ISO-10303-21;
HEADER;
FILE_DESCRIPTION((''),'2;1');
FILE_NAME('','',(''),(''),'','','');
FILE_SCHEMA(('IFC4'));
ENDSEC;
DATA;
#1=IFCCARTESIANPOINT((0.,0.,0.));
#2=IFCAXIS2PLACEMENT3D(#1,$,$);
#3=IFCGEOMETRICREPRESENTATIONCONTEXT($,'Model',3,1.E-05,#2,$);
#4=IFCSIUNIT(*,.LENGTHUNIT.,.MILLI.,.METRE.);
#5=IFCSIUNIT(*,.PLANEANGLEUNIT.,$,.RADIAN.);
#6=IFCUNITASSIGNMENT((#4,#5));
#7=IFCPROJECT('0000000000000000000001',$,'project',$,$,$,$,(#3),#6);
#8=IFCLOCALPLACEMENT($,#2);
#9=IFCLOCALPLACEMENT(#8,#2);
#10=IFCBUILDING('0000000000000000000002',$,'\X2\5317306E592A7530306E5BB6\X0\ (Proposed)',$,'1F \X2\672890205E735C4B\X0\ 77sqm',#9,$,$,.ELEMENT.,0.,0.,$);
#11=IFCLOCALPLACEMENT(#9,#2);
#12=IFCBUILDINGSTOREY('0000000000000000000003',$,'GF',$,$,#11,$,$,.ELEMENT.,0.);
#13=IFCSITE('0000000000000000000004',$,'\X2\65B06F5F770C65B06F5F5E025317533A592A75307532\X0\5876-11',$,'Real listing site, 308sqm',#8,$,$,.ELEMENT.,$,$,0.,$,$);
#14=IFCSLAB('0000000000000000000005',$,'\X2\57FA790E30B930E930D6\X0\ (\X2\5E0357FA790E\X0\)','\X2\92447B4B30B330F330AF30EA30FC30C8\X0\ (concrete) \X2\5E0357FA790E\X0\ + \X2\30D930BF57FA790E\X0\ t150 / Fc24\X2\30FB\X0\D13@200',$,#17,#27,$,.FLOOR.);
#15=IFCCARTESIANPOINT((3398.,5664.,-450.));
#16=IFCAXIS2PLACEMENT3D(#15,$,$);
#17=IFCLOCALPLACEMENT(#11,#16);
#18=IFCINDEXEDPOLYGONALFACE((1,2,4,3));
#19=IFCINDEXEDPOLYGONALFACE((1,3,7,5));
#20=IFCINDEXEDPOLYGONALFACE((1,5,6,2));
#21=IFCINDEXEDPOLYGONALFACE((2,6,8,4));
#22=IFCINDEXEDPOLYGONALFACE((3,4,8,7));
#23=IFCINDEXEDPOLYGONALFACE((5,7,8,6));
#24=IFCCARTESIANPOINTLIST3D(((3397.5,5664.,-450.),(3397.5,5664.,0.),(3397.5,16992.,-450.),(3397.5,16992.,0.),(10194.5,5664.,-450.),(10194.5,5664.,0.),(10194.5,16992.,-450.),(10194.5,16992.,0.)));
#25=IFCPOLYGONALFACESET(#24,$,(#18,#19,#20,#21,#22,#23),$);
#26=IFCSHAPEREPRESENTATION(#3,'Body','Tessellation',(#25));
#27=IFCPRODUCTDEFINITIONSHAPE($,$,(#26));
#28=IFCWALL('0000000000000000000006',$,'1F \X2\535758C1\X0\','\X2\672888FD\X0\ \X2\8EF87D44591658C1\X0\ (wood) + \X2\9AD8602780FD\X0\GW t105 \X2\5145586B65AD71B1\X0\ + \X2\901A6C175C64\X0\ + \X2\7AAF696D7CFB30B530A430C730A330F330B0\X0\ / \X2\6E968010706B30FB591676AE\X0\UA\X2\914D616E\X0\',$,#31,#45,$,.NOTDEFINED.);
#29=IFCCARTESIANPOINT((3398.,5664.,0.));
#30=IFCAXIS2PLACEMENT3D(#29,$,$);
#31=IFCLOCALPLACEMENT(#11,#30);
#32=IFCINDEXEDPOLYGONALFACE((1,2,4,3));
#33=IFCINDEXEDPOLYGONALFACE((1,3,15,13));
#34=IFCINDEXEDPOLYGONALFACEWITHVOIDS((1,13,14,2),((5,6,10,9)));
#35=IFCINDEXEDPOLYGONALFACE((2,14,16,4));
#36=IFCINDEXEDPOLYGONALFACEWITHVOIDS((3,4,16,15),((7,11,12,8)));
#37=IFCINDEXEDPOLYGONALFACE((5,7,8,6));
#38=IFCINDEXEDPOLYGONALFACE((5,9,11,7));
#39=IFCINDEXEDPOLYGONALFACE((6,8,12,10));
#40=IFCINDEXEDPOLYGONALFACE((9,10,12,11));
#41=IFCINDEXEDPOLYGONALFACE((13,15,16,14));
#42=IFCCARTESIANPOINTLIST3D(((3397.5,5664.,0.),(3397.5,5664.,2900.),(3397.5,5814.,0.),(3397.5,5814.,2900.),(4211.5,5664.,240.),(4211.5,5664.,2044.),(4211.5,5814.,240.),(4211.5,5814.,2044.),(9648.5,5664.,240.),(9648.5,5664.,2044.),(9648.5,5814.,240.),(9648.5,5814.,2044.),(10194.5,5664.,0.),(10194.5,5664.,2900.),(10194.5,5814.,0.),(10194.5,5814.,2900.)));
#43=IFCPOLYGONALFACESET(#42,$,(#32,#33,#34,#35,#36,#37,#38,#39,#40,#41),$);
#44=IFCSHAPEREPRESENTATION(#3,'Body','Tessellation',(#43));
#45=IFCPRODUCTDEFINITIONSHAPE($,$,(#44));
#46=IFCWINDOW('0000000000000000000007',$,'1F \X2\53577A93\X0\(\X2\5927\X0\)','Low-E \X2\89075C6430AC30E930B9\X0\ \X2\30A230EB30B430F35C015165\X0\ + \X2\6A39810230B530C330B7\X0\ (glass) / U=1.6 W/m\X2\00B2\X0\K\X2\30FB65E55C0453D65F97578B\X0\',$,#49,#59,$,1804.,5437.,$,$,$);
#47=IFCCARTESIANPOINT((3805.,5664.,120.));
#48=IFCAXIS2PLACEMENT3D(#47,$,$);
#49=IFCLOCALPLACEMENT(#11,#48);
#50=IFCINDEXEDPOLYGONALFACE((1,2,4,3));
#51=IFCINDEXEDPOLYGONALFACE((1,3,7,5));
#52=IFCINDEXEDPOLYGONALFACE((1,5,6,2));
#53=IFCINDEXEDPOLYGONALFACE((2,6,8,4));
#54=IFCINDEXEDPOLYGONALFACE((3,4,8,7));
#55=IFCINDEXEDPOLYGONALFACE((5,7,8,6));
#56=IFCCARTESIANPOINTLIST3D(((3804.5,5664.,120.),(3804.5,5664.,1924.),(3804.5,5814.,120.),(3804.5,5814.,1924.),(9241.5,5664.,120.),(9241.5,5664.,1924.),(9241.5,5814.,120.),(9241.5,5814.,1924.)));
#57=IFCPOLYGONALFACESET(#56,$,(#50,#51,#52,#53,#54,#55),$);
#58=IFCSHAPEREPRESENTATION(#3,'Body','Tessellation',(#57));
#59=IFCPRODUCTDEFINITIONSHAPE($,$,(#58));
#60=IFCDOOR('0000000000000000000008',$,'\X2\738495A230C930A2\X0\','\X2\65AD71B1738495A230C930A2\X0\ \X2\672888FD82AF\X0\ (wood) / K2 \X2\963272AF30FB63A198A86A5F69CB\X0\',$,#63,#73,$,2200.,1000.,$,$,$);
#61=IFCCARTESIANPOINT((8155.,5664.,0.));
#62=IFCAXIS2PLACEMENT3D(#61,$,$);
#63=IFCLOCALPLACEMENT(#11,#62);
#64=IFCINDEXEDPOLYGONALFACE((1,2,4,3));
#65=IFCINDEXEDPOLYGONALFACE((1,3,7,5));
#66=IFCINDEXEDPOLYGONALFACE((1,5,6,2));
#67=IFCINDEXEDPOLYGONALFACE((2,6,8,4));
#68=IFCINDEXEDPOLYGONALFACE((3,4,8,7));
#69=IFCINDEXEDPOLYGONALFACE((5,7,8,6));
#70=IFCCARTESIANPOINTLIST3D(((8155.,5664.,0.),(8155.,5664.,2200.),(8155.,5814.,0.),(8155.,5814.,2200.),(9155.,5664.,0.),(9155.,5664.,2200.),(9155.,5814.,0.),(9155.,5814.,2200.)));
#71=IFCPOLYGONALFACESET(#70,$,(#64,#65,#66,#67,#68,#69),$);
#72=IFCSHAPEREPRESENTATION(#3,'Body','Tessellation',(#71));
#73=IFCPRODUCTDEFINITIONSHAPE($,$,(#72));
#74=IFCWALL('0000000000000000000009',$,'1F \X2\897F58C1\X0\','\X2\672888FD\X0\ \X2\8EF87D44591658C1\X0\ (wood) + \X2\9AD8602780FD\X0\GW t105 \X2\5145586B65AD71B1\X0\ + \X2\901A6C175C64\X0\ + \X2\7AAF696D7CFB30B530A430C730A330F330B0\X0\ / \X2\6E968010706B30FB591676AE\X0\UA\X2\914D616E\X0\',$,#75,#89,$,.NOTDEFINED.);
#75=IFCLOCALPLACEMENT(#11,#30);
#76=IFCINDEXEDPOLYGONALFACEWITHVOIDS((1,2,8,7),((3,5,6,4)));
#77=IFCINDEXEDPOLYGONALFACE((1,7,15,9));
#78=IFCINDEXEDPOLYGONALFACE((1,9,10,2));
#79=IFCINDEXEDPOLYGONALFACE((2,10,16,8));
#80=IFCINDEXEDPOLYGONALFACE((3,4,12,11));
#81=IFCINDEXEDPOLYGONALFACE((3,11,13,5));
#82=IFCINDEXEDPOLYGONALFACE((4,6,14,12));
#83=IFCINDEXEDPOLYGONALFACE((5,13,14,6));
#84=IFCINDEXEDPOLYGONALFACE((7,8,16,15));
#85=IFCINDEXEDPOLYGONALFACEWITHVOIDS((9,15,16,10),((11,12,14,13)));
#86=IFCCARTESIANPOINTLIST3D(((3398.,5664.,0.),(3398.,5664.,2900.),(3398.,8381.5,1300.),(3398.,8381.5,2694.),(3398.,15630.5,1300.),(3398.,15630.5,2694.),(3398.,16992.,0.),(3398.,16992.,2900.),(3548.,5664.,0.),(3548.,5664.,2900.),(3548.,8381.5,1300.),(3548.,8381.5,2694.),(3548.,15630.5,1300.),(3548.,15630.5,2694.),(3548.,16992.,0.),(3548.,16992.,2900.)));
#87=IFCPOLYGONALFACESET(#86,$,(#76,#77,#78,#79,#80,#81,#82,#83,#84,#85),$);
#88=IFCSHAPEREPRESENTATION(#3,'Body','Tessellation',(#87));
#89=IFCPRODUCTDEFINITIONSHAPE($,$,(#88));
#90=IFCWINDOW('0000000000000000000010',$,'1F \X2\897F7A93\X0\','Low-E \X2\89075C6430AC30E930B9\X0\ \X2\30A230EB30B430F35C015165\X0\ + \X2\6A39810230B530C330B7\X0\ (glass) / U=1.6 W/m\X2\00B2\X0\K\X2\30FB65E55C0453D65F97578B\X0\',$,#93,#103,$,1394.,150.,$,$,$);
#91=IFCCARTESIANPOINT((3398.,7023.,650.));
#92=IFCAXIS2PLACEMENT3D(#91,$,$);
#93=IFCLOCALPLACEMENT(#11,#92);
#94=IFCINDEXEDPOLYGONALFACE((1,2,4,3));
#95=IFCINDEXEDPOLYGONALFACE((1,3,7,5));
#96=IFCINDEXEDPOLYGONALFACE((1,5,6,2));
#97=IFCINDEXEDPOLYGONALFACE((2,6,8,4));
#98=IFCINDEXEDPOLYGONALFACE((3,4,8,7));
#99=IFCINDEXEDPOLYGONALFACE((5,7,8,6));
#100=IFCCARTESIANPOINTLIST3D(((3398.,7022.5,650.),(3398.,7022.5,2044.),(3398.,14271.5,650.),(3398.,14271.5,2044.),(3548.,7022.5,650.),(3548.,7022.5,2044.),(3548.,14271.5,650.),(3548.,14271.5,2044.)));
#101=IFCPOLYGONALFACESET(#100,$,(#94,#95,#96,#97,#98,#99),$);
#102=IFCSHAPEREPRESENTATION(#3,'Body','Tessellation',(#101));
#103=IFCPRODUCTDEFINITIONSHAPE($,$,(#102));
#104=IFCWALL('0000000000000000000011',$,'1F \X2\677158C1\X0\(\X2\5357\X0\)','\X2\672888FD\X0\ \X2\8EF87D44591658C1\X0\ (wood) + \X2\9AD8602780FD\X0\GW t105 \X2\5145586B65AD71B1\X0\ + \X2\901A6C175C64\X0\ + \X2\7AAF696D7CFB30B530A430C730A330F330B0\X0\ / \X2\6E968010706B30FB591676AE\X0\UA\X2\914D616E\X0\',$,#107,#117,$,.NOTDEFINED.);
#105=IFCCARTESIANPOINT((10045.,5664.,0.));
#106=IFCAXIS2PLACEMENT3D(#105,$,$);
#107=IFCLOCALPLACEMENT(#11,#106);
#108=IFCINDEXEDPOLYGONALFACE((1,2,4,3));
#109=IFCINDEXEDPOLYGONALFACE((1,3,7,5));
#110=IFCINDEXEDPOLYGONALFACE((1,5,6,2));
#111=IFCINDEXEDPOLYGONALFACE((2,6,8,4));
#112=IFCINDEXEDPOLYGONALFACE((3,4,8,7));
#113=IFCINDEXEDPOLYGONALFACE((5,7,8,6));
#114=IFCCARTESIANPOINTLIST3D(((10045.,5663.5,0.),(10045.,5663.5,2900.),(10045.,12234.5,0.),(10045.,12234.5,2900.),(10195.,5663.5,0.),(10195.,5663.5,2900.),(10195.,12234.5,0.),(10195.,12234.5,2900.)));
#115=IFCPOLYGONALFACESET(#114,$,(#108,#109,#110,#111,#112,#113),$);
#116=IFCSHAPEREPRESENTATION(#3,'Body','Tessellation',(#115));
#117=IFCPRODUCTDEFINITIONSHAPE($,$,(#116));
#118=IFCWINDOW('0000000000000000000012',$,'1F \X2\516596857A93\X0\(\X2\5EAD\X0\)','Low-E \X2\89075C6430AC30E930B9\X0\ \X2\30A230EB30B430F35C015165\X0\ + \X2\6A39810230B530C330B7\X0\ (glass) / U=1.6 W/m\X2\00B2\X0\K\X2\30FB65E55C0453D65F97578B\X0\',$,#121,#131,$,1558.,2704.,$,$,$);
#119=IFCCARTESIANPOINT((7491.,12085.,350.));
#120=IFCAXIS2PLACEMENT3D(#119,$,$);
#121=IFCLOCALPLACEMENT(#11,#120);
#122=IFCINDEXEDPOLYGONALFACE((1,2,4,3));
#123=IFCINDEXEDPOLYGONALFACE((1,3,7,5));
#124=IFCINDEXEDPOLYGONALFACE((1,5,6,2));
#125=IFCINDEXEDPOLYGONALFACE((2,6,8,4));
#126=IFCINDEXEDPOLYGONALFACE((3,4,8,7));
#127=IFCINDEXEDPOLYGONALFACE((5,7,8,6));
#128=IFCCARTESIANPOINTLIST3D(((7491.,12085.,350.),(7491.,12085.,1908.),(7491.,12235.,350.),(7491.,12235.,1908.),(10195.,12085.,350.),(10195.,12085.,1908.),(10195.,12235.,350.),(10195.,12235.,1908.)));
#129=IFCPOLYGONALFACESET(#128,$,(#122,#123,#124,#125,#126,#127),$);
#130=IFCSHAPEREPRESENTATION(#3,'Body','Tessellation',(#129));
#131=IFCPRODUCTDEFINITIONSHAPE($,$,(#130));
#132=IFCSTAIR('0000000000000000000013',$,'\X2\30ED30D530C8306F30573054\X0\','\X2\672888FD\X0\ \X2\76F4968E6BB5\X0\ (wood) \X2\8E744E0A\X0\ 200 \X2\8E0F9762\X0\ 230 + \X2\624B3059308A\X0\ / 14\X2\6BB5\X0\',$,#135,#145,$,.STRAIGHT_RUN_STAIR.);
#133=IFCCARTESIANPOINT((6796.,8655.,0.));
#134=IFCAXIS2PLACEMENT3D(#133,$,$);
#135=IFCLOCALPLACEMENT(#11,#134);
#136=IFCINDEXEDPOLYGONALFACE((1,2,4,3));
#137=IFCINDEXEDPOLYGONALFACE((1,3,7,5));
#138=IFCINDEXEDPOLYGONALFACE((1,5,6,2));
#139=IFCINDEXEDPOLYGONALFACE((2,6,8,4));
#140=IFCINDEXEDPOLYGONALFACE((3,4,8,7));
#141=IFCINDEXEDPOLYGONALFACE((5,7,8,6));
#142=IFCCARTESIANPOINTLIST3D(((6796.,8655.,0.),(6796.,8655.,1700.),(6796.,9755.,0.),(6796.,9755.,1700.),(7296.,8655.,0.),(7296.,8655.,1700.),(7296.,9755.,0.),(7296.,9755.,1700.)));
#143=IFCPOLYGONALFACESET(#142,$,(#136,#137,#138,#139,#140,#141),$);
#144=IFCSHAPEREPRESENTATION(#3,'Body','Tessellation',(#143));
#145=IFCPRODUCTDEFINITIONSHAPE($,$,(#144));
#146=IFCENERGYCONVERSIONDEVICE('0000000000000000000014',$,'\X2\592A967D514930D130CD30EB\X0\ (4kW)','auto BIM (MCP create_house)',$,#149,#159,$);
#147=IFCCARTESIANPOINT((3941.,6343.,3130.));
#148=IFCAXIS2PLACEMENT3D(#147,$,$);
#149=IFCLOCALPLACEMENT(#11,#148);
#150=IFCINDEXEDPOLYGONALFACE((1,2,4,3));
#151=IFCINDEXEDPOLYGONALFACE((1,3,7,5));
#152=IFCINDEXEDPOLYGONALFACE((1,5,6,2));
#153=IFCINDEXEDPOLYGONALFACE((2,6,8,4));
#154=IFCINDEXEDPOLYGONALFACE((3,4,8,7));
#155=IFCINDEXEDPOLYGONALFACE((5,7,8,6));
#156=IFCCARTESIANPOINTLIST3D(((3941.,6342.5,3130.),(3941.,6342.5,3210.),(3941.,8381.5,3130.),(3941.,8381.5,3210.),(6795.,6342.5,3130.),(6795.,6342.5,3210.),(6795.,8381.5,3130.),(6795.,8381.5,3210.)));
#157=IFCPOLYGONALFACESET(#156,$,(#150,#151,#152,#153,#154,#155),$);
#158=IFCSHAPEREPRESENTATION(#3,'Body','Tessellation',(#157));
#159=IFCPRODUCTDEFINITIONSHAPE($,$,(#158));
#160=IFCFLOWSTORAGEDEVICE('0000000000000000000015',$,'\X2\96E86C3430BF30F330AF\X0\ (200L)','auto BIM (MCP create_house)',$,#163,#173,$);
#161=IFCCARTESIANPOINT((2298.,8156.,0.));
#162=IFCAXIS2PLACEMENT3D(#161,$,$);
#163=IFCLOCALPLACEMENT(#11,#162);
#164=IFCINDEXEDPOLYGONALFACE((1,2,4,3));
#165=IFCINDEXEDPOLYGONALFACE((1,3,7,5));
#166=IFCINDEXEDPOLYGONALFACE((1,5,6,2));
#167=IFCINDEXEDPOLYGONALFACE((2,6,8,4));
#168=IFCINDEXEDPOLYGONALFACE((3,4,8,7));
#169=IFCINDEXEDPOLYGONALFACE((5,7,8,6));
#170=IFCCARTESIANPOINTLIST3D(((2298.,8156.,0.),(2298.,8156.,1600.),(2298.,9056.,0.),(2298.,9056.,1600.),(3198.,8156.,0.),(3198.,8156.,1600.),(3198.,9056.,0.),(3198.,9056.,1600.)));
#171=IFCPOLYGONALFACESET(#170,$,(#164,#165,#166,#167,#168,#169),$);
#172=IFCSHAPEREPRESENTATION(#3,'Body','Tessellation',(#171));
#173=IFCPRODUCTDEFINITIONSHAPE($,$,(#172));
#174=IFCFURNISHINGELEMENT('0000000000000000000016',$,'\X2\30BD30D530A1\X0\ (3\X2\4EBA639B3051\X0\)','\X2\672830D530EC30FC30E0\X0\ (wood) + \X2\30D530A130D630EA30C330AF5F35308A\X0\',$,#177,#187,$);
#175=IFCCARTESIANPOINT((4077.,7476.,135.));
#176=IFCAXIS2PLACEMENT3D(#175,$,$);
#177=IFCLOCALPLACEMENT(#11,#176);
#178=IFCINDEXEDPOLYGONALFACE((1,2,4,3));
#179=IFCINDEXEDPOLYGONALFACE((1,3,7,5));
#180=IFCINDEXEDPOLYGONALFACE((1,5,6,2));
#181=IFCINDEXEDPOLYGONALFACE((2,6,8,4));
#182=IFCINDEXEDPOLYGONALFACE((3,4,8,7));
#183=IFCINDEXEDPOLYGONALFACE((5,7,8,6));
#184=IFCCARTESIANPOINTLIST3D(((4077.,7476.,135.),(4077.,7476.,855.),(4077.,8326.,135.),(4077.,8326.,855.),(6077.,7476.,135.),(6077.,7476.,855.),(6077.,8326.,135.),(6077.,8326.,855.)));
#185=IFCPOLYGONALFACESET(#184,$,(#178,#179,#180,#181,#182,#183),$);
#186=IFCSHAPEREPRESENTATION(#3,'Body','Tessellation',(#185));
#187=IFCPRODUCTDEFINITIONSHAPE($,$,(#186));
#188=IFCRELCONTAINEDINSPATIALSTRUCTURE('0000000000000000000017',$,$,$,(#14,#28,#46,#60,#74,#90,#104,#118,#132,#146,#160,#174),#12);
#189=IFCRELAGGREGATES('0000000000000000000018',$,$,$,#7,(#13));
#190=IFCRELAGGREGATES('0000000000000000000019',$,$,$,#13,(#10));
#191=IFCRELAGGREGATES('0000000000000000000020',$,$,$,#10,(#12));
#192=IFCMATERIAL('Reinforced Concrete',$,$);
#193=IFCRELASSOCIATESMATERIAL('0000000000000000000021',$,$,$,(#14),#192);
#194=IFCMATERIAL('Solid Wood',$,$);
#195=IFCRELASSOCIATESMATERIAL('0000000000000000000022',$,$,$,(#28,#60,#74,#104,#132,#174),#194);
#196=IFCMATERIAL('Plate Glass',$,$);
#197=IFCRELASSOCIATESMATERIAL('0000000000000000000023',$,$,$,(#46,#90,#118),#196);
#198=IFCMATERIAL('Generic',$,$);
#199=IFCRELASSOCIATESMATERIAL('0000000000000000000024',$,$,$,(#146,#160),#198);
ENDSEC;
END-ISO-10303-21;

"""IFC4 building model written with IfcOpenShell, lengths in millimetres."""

from ifc_helpers import new_model, si_unit, frame, frame_2d, origin, place, context, project, spatial, rectangle, extrude, material, element, fill, save


model = new_model("IFC4")

# Units and contexts
model_context = context("Model", 3, precision=1e-05, world=origin())
ifc_project = project(units=[si_unit("LENGTHUNIT", "METRE", prefix="MILLI"), si_unit("PLANEANGLEUNIT", "RADIAN")], contexts=[model_context])

# Site, building, storey
site_placement = place(None, origin())
site = spatial("IfcSite", under=ifc_project, at=site_placement, Name="新潟県新潟市北区太田甲5876-11", ObjectType="Real listing site, 308sqm", CompositionType="ELEMENT", RefElevation=0.0)
building_placement = place(site_placement, origin())
building = spatial("IfcBuilding", under=site, at=building_placement, Name="北の太田の家 (Proposed)", ObjectType="1F 木造平屋 77sqm", CompositionType="ELEMENT", ElevationOfRefHeight=0.0, ElevationOfTerrain=0.0)
storey_placement = place(building_placement, origin())
storey = spatial("IfcBuildingStorey", under=building, at=storey_placement, Name="GF", CompositionType="ELEMENT", Elevation=0.0)

# Slab
ifc_material_1 = material(Name="Reinforced Concrete")
slab_1_placement = place(storey_placement, frame((3398.0, 5664.0, -450.0)))
element("IfcSlab", 1, at=slab_1_placement, inside=storey, material=ifc_material_1, Name="基礎スラブ (布基礎)", Description="鉄筋コンクリート (concrete) 布基礎 + ベタ基礎 t150 / Fc24・D13@200", PredefinedType="FLOOR", context=model_context, shape_type="SweptSolid", body=[
    extrude(rectangle(XDim=6797.0, YDim=11328.0, at=frame_2d((3398.0, 5664.0))), frame((3398.0, 5664.0, -450.0)), (0.0, 0.0, 1.0), 450.0),
])
ifc_material_2 = material(Name="Solid Wood")

# Wall, openings, window, door
wall_1_placement = place(storey_placement, frame((3398.0, 5664.0, 0.0)))
wall_1 = element("IfcWall", 2, at=wall_1_placement, inside=storey, material=ifc_material_2, Name="1F 南壁", Description="木製 軸組外壁 (wood) + 高性能GW t105 充填断熱 + 通気層 + 窯業系サイディング / 準耐火・外皮UA配慮", PredefinedType="NOTDEFINED", context=model_context, shape_type="SweptSolid", body=[
    extrude(rectangle(XDim=6797.0, YDim=150.0, at=frame_2d((3398.0, 75.0))), frame((3398.0, 5664.0, 0.0)), (0.0, 0.0, 1.0), 2900.0),
])
opening_1_placement = place(storey_placement, frame((3805.0, 5664.0, 120.0)))
opening_1 = element("IfcOpeningElement", 3, at=opening_1_placement, cuts=wall_1, PredefinedType="NOTDEFINED", context=model_context, shape_type="SweptSolid", body=[
    extrude(rectangle(XDim=5437.0, YDim=150.0, at=frame_2d((2718.0, 75.0))), frame((3805.0, 5664.0, 120.0)), (0.0, 0.0, 1.0), 1804.0),
])
opening_2_placement = place(storey_placement, frame((8155.0, 5664.0, 0.0)))
opening_2 = element("IfcOpeningElement", 4, at=opening_2_placement, cuts=wall_1, PredefinedType="NOTDEFINED", context=model_context, shape_type="SweptSolid", body=[
    extrude(rectangle(XDim=1000.0, YDim=150.0, at=frame_2d((500.0, 75.0))), frame((8155.0, 5664.0, 0.0)), (0.0, 0.0, 1.0), 2200.0),
])
ifc_material_3 = material(Name="Plate Glass")
window_1_placement = place(storey_placement, frame((3805.0, 5664.0, 120.0)))
window_1 = element("IfcWindow", 5, at=window_1_placement, inside=storey, material=ifc_material_3, Name="1F 南窓(大)", Description="Low-E 複層ガラス アルゴン封入 + 樹脂サッシ (glass) / U=1.6 W/m²K・日射取得型", OverallHeight=1804.0, OverallWidth=5437.0, context=model_context, shape_type="SweptSolid", body=[
    extrude(rectangle(XDim=5437.0, YDim=150.0, at=frame_2d((2718.0, 75.0))), frame((3805.0, 5664.0, 120.0)), (0.0, 0.0, 1.0), 1804.0),
])
fill(opening_1, window_1)
door_1_placement = place(storey_placement, frame((8155.0, 5664.0, 0.0)))
door_1 = element("IfcDoor", 6, at=door_1_placement, inside=storey, material=ifc_material_2, Name="玄関ドア", Description="断熱玄関ドア 木製芯 (wood) / K2 防犯・採風機構", OverallHeight=2200.0, OverallWidth=1000.0, context=model_context, shape_type="SweptSolid", body=[
    extrude(rectangle(XDim=1000.0, YDim=150.0, at=frame_2d((500.0, 75.0))), frame((8155.0, 5664.0, 0.0)), (0.0, 0.0, 1.0), 2200.0),
])
fill(opening_2, door_1)

# Walls, openings, windows
wall_2_placement = place(storey_placement, frame((3398.0, 5664.0, 0.0)))
wall_2 = element("IfcWall", 7, at=wall_2_placement, inside=storey, material=ifc_material_2, Name="1F 西壁", Description="木製 軸組外壁 (wood) + 高性能GW t105 充填断熱 + 通気層 + 窯業系サイディング / 準耐火・外皮UA配慮", PredefinedType="NOTDEFINED", context=model_context, shape_type="SweptSolid", body=[
    extrude(rectangle(XDim=150.0, YDim=11328.0, at=frame_2d((75.0, 5664.0))), frame((3398.0, 5664.0, 0.0)), (0.0, 0.0, 1.0), 2900.0),
])
opening_3_placement = place(storey_placement, frame((3398.0, 7023.0, 650.0)))
opening_3 = element("IfcOpeningElement", 8, at=opening_3_placement, cuts=wall_2, PredefinedType="NOTDEFINED", context=model_context, shape_type="SweptSolid", body=[
    extrude(rectangle(XDim=150.0, YDim=7249.0, at=frame_2d((75.0, 3624.0))), frame((3398.0, 7023.0, 650.0)), (0.0, 0.0, 1.0), 1394.0),
])
window_2_placement = place(storey_placement, frame((3398.0, 7023.0, 650.0)))
window_2 = element("IfcWindow", 9, at=window_2_placement, inside=storey, material=ifc_material_3, Name="1F 西窓", Description="Low-E 複層ガラス アルゴン封入 + 樹脂サッシ (glass) / U=1.6 W/m²K・日射取得型", OverallHeight=1394.0, OverallWidth=150.0, context=model_context, shape_type="SweptSolid", body=[
    extrude(rectangle(XDim=150.0, YDim=7249.0, at=frame_2d((75.0, 3624.0))), frame((3398.0, 7023.0, 650.0)), (0.0, 0.0, 1.0), 1394.0),
])
fill(opening_3, window_2)
wall_3_placement = place(storey_placement, frame((10045.0, 5664.0, 0.0)))
wall_3 = element("IfcWall", 10, at=wall_3_placement, inside=storey, material=ifc_material_2, Name="1F 東壁(南)", Description="木製 軸組外壁 (wood) + 高性能GW t105 充填断熱 + 通気層 + 窯業系サイディング / 準耐火・外皮UA配慮", PredefinedType="NOTDEFINED", context=model_context, shape_type="SweptSolid", body=[
    extrude(rectangle(XDim=150.0, YDim=6571.0, at=frame_2d((75.0, 3285.0))), frame((10045.0, 5664.0, 0.0)), (0.0, 0.0, 1.0), 2900.0),
])
opening_4_placement = place(storey_placement, frame((7491.0, 12085.0, 350.0)))
opening_4 = element("IfcOpeningElement", 11, at=opening_4_placement, cuts=wall_3, PredefinedType="NOTDEFINED", context=model_context, shape_type="SweptSolid", body=[
    extrude(rectangle(XDim=2704.0, YDim=150.0, at=frame_2d((1352.0, 75.0))), frame((7491.0, 12085.0, 350.0)), (0.0, 0.0, 1.0), 1558.0),
])
window_3_placement = place(storey_placement, frame((7491.0, 12085.0, 350.0)))
window_3 = element("IfcWindow", 12, at=window_3_placement, inside=storey, material=ifc_material_3, Name="1F 入隅窓(庭)", Description="Low-E 複層ガラス アルゴン封入 + 樹脂サッシ (glass) / U=1.6 W/m²K・日射取得型", OverallHeight=1558.0, OverallWidth=2704.0, context=model_context, shape_type="SweptSolid", body=[
    extrude(rectangle(XDim=2704.0, YDim=150.0, at=frame_2d((1352.0, 75.0))), frame((7491.0, 12085.0, 350.0)), (0.0, 0.0, 1.0), 1558.0),
])
fill(opening_4, window_3)

# Stair
stair_placement = place(storey_placement, frame((6796.0, 8655.0, 0.0)))
element("IfcStair", 13, at=stair_placement, inside=storey, material=ifc_material_2, Name="ロフトはしご", Description="木製 直階段 (wood) 蹴上 200 踏面 230 + 手すり / 14段", PredefinedType="STRAIGHT_RUN_STAIR", context=model_context, shape_type="SweptSolid", body=[
    extrude(rectangle(XDim=500.0, YDim=1100.0, at=frame_2d((250.0, 550.0))), frame((6796.0, 8655.0, 0.0)), (0.0, 0.0, 1.0), 1700.0),
])

# Shared definitions
ifc_material_4 = material(Name="Generic")

# Energy conversion device
energy_conversion_device_placement = place(storey_placement, frame((3941.0, 6343.0, 3130.0)))
element("IfcEnergyConversionDevice", 14, at=energy_conversion_device_placement, inside=storey, material=ifc_material_4, Name="太陽光パネル (4kW)", Description="auto BIM (MCP create_house)", context=model_context, shape_type="SweptSolid", body=[
    extrude(rectangle(XDim=2854.0, YDim=2039.0, at=frame_2d((1427.0, 1019.0))), frame((3941.0, 6343.0, 3130.0)), (0.0, 0.0, 1.0), 80.0),
])

# Flow storage device
flow_storage_device_placement = place(storey_placement, frame((2298.0, 8156.0, 0.0)))
element("IfcFlowStorageDevice", 15, at=flow_storage_device_placement, inside=storey, material=ifc_material_4, Name="雨水タンク (200L)", Description="auto BIM (MCP create_house)", context=model_context, shape_type="SweptSolid", body=[
    extrude(rectangle(XDim=900.0, YDim=900.0, at=frame_2d((450.0, 450.0))), frame((2298.0, 8156.0, 0.0)), (0.0, 0.0, 1.0), 1600.0),
])

# Furnishing element
furnishing_1_placement = place(storey_placement, frame((4077.0, 7476.0, 135.0)))
element("IfcFurnishingElement", 16, at=furnishing_1_placement, inside=storey, material=ifc_material_2, Name="ソファ (3人掛け)", Description="木フレーム (wood) + ファブリック張り", context=model_context, shape_type="SweptSolid", body=[
    extrude(rectangle(XDim=2000.0, YDim=850.0, at=frame_2d((1000.0, 425.0))), frame((4077.0, 7476.0, 135.0)), (0.0, 0.0, 1.0), 720.0),
])

save(model, "model.ifc")
